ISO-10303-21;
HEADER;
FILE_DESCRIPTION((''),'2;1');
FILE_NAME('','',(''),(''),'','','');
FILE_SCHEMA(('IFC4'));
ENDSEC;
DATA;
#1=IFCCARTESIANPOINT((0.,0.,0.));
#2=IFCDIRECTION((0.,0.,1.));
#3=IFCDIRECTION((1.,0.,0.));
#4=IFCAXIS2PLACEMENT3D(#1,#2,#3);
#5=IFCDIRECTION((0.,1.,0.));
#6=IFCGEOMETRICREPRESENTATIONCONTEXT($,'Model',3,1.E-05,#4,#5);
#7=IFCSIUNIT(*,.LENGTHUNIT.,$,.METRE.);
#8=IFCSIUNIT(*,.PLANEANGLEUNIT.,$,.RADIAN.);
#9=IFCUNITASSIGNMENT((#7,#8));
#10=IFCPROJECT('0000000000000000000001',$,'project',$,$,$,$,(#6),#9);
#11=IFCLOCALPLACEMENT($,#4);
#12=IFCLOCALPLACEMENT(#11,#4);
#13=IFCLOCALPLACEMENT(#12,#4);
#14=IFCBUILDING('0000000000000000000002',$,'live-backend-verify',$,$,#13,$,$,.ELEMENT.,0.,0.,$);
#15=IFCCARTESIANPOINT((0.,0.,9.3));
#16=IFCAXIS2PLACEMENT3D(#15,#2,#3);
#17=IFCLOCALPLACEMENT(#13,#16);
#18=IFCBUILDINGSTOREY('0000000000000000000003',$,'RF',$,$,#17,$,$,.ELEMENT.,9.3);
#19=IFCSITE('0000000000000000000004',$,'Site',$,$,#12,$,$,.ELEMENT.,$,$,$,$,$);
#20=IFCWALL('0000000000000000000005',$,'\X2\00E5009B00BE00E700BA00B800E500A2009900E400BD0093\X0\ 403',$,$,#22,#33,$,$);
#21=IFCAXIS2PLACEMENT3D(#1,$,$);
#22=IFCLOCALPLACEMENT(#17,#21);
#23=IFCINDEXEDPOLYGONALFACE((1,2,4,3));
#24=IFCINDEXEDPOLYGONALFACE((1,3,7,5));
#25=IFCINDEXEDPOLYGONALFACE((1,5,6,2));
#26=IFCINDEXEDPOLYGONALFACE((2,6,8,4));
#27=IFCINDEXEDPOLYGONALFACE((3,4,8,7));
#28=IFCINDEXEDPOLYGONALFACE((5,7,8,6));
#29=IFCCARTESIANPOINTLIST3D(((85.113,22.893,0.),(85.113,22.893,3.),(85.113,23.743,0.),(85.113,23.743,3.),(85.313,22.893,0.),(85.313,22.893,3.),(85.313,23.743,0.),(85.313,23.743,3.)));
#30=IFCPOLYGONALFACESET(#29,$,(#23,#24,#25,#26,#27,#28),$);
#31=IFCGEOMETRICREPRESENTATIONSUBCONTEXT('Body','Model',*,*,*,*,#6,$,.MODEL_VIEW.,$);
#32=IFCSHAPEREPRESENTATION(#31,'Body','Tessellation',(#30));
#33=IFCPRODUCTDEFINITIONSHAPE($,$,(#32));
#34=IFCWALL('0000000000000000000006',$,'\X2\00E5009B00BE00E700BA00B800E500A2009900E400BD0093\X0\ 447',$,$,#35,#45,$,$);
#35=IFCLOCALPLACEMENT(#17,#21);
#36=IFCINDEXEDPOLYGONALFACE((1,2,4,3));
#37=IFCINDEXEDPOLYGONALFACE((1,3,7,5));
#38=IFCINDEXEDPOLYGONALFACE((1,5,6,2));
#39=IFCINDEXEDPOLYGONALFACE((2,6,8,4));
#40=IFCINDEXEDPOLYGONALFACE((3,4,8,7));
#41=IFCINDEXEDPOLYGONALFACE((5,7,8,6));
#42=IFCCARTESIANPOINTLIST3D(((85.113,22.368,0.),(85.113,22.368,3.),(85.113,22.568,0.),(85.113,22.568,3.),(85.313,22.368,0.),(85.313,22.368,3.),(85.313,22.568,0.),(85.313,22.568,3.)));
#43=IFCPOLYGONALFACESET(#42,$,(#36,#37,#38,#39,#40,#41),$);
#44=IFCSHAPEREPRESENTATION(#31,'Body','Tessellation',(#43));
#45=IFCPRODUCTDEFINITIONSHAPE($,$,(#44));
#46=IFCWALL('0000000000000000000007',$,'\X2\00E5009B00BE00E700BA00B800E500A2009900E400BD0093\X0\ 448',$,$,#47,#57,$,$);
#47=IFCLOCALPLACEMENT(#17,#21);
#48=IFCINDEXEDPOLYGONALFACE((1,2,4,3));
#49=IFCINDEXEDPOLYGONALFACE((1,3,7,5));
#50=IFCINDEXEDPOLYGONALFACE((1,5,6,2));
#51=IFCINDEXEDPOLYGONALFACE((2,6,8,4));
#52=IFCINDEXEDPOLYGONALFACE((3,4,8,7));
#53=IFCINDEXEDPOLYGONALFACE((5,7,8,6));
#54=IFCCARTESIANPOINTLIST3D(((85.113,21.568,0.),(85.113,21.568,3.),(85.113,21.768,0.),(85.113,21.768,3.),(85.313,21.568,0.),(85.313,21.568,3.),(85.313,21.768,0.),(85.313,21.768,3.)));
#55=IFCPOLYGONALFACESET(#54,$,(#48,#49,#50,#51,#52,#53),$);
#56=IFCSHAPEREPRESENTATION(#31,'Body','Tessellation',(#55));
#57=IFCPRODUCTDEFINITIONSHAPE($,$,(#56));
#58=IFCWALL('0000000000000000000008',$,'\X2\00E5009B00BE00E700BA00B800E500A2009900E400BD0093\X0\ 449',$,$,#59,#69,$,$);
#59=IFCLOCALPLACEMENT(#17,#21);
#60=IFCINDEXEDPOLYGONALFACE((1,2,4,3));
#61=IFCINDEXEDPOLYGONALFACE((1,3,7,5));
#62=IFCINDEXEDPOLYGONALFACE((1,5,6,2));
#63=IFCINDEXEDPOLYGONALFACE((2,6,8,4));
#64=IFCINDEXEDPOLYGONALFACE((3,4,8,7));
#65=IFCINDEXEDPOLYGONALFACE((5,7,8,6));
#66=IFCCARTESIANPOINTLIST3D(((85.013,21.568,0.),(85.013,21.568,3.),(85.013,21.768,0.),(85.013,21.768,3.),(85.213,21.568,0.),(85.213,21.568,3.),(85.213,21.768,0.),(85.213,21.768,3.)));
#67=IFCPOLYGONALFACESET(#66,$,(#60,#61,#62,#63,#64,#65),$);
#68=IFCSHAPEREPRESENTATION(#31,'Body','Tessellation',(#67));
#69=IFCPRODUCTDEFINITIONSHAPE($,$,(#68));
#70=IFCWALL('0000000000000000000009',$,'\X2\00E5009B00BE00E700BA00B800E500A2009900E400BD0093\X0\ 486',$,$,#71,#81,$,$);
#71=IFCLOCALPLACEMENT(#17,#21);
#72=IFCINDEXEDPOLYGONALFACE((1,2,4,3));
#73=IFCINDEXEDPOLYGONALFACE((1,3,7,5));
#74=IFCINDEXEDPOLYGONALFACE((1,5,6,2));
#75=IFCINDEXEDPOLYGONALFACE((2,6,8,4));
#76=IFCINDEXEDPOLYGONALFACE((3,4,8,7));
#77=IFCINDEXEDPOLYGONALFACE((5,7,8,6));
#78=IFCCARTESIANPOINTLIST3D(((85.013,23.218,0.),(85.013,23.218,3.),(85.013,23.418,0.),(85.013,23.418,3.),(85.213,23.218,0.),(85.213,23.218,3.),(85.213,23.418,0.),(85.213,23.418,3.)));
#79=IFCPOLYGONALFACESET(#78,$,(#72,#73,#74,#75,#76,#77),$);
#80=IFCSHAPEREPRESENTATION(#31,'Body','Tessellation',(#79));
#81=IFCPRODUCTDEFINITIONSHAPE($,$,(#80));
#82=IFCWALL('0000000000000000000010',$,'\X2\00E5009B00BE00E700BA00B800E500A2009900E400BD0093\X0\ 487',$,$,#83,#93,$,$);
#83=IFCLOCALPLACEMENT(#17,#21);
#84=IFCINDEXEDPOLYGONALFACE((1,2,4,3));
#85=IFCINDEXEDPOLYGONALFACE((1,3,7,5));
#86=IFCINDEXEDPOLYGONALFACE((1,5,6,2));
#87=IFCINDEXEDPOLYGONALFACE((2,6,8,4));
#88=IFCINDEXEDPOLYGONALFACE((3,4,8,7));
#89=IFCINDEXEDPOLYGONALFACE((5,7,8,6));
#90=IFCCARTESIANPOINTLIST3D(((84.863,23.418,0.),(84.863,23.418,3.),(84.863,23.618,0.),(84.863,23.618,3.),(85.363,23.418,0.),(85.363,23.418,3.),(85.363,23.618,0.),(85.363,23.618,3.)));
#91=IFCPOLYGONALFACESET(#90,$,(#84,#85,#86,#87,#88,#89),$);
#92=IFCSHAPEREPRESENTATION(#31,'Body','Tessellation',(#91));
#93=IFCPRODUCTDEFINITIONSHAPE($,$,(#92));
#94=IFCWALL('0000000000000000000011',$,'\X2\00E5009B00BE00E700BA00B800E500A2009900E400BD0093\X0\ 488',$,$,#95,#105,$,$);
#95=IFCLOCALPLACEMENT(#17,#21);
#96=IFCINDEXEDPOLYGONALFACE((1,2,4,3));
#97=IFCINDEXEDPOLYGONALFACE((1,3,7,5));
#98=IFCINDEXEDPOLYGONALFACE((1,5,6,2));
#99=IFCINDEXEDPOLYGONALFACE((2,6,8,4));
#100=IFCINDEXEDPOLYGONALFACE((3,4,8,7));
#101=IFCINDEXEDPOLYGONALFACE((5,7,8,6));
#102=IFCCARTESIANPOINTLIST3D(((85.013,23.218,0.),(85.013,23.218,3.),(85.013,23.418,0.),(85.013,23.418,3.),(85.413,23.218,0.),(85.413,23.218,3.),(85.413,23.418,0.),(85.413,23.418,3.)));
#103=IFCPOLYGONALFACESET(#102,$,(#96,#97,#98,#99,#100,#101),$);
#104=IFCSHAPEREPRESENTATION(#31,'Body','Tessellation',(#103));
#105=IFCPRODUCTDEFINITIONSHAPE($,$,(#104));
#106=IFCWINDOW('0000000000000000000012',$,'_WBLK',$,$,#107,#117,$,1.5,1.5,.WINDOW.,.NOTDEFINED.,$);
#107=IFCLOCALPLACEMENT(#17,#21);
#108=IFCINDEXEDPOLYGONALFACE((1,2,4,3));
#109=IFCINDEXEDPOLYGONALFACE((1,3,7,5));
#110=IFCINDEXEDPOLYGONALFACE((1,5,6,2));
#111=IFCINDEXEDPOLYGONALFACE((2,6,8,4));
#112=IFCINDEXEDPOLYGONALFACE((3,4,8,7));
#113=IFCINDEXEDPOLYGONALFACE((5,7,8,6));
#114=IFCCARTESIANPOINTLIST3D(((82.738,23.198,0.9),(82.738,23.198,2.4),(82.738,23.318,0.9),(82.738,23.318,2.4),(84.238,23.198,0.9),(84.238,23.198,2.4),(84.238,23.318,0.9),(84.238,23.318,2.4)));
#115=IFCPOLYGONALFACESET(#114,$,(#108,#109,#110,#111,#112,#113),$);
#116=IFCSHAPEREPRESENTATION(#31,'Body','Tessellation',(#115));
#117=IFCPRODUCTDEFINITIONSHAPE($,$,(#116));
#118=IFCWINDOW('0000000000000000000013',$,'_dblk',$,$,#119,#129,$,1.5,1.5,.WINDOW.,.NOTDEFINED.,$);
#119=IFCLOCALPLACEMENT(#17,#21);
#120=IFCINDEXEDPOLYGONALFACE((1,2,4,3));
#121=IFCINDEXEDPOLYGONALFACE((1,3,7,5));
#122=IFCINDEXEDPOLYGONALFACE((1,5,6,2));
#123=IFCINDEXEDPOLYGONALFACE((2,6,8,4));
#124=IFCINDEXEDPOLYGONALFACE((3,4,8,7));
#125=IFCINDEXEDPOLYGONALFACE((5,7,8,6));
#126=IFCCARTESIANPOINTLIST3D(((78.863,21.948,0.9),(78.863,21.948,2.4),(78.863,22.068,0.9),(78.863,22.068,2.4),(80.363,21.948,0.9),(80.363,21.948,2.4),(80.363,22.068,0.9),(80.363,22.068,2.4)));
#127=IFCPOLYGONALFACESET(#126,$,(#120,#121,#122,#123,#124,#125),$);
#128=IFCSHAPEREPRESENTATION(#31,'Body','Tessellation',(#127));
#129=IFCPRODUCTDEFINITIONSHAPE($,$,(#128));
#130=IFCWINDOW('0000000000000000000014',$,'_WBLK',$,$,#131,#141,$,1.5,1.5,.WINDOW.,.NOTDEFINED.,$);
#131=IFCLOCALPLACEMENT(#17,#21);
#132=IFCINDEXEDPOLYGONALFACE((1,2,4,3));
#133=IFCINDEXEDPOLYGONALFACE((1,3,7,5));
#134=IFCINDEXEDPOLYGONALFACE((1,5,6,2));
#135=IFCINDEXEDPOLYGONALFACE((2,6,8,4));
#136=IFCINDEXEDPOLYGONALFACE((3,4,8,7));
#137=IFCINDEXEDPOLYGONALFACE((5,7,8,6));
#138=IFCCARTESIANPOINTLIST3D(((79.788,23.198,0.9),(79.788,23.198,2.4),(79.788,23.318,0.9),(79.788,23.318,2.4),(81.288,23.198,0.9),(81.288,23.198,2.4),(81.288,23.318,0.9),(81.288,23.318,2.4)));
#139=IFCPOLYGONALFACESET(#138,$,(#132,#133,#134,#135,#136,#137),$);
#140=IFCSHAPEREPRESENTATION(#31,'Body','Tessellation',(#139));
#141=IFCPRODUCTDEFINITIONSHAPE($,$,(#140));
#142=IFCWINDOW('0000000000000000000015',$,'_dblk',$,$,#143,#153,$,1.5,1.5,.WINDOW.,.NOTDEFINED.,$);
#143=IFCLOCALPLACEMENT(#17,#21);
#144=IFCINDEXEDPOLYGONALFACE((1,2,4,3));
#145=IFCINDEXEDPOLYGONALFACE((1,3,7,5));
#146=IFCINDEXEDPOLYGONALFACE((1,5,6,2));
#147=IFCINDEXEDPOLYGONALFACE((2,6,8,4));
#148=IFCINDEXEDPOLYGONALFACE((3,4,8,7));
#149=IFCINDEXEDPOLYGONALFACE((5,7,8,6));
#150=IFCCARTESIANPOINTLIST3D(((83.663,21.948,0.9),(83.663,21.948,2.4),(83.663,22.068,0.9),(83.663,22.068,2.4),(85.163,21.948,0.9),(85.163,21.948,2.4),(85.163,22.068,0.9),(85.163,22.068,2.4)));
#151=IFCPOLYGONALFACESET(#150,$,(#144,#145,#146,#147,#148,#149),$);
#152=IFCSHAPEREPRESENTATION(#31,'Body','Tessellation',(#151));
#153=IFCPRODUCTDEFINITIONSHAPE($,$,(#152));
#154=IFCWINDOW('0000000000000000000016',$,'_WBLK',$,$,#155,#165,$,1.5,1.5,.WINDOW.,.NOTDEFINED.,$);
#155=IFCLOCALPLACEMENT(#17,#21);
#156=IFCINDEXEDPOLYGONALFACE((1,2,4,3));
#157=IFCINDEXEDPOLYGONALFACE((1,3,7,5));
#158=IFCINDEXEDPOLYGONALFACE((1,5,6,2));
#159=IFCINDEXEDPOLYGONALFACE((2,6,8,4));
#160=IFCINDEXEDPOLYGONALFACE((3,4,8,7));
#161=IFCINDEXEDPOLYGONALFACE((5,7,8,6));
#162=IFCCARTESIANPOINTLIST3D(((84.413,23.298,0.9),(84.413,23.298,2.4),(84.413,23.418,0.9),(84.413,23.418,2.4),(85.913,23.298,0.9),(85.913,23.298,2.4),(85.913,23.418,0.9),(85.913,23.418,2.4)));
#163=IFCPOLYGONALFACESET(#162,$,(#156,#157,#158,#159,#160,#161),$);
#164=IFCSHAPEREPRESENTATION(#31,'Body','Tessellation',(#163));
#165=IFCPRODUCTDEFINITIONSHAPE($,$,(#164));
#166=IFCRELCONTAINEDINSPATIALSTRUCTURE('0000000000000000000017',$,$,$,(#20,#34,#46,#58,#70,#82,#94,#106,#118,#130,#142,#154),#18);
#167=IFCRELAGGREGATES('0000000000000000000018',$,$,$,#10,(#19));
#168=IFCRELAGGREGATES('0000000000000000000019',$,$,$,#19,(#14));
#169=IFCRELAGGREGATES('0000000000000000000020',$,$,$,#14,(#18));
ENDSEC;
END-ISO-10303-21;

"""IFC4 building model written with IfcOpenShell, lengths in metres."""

from ifc_helpers import new_model, si_unit, direction, frame, frame_2d, origin_with_axes, place, context, subcontext, project, spatial, rectangle, extrude, element, save


model = new_model("IFC4")

# Units and contexts
model_context = context("Model", 3, precision=1e-05, world=origin_with_axes(), true_north=direction((0.0, 1.0, 0.0)))
body_context = subcontext(model_context, "Body", "Model", "MODEL_VIEW")
ifc_project = project(units=[si_unit("LENGTHUNIT", "METRE"), si_unit("PLANEANGLEUNIT", "RADIAN")], contexts=[model_context])

# Site, building, storey
placement = place(None, origin_with_axes())
site_placement = place(placement, origin_with_axes())
site = spatial("IfcSite", under=ifc_project, at=site_placement, Name="Site", CompositionType="ELEMENT")
building_placement = place(site_placement, origin_with_axes())
building = spatial("IfcBuilding", under=site, at=building_placement, Name="live-backend-verify", CompositionType="ELEMENT", ElevationOfRefHeight=0.0, ElevationOfTerrain=0.0)
storey_placement = place(building_placement, frame((0.0, 0.0, 9.3), z_axis=(0.0, 0.0, 1.0), x_axis=(1.0, 0.0, 0.0)))
storey = spatial("IfcBuildingStorey", under=building, at=storey_placement, Name="RF", CompositionType="ELEMENT", Elevation=9.3)

# Walls
for number, where, z_axis, x_axis, name in (
    (1, (85.213, 23.318, 0.0), (0.0, 0.0, 1.0), (0.0, -1.0, 0.0), "å\u009b¾çº¸å¢\u0099ä½\u0093 403"),
):
    element("IfcWall", number, at=place(storey_placement, frame(where, z_axis=z_axis, x_axis=x_axis)), inside=storey, Name=name, context=body_context, shape_type="SweptSolid", body=[
        extrude(rectangle(XDim=0.85, YDim=0.2, at=frame_2d((0.0, 0.0), x_axis=(1.0, 0.0, 0.0))), frame((0.0, 0.0, 0.0), z_axis=(0.0, 0.0, 1.0)), (0.0, 0.0, 1.0), 3.0),
    ])
for number, where, z_axis, x_axis, name in (
    (2, (85.213, 22.468, 0.0), (0.0, 0.0, 1.0), (-1.0, 0.0, 0.0), "å\u009b¾çº¸å¢\u0099ä½\u0093 447"),
    (3, (85.213, 21.668, 0.0), (0.0, 0.0, 1.0), (-1.0, 0.0, 0.0), "å\u009b¾çº¸å¢\u0099ä½\u0093 448"),
    (4, (85.113, 21.668, 0.0), (0.0, 0.0, 1.0), (0.0, -1.0, 0.0), "å\u009b¾çº¸å¢\u0099ä½\u0093 449"),
    (5, (85.113, 23.318, 0.0), (0.0, 0.0, 1.0), (0.0, 1.0, 0.0), "å\u009b¾çº¸å¢\u0099ä½\u0093 486"),
):
    element("IfcWall", number, at=place(storey_placement, frame(where, z_axis=z_axis, x_axis=x_axis)), inside=storey, Name=name, context=body_context, shape_type="SweptSolid", body=[
        extrude(rectangle(XDim=0.2, YDim=0.2, at=frame_2d((0.0, 0.0), x_axis=(1.0, 0.0, 0.0))), frame((0.0, 0.0, 0.0), z_axis=(0.0, 0.0, 1.0)), (0.0, 0.0, 1.0), 3.0),
    ])
wall_1_placement = place(storey_placement, frame((85.113, 23.518, 0.0), z_axis=(0.0, 0.0, 1.0), x_axis=(1.0, 0.0, 0.0)))
element("IfcWall", 6, at=wall_1_placement, inside=storey, Name="å\u009b¾çº¸å¢\u0099ä½\u0093 487", context=body_context, shape_type="SweptSolid", body=[
    extrude(rectangle(XDim=0.5, YDim=0.2, at=frame_2d((0.0, 0.0), x_axis=(1.0, 0.0, 0.0))), frame((0.0, 0.0, 0.0), z_axis=(0.0, 0.0, 1.0)), (0.0, 0.0, 1.0), 3.0),
])
wall_2_placement = place(storey_placement, frame((85.213, 23.318, 0.0), z_axis=(0.0, 0.0, 1.0), x_axis=(1.0, 0.0, 0.0)))
element("IfcWall", 7, at=wall_2_placement, inside=storey, Name="å\u009b¾çº¸å¢\u0099ä½\u0093 488", context=body_context, shape_type="SweptSolid", body=[
    extrude(rectangle(XDim=0.4, YDim=0.2, at=frame_2d((0.0, 0.0), x_axis=(1.0, 0.0, 0.0))), frame((0.0, 0.0, 0.0), z_axis=(0.0, 0.0, 1.0)), (0.0, 0.0, 1.0), 3.0),
])

# Windows
for number, where, z_axis, x_axis, name in (
    (8, (83.488, 23.258, 0.9), (0.0, 0.0, 1.0), (1.0, 0.0, 0.0), "_WBLK"),
    (9, (79.613, 22.008, 0.9), (0.0, 0.0, 1.0), (1.0, 0.0, 0.0), "_dblk"),
    (10, (80.538, 23.258, 0.9), (0.0, 0.0, 1.0), (1.0, 0.0, 0.0), "_WBLK"),
    (11, (84.413, 22.008, 0.9), (0.0, 0.0, 1.0), (1.0, 0.0, 0.0), "_dblk"),
    (12, (85.163, 23.358, 0.9), (0.0, 0.0, 1.0), (1.0, 0.0, 0.0), "_WBLK"),
):
    element("IfcWindow", number, at=place(storey_placement, frame(where, z_axis=z_axis, x_axis=x_axis)), inside=storey, Name=name, OverallHeight=1.5, OverallWidth=1.5, PartitioningType="NOTDEFINED", PredefinedType="WINDOW", context=body_context, shape_type="SweptSolid", body=[
        extrude(rectangle(XDim=1.5, YDim=0.12, at=frame_2d((0.0, 0.0), x_axis=(1.0, 0.0, 0.0))), frame((0.0, 0.0, 0.0), z_axis=(0.0, 0.0, 1.0)), (0.0, 0.0, 1.0), 1.5),
    ])

save(model, "model.ifc")
